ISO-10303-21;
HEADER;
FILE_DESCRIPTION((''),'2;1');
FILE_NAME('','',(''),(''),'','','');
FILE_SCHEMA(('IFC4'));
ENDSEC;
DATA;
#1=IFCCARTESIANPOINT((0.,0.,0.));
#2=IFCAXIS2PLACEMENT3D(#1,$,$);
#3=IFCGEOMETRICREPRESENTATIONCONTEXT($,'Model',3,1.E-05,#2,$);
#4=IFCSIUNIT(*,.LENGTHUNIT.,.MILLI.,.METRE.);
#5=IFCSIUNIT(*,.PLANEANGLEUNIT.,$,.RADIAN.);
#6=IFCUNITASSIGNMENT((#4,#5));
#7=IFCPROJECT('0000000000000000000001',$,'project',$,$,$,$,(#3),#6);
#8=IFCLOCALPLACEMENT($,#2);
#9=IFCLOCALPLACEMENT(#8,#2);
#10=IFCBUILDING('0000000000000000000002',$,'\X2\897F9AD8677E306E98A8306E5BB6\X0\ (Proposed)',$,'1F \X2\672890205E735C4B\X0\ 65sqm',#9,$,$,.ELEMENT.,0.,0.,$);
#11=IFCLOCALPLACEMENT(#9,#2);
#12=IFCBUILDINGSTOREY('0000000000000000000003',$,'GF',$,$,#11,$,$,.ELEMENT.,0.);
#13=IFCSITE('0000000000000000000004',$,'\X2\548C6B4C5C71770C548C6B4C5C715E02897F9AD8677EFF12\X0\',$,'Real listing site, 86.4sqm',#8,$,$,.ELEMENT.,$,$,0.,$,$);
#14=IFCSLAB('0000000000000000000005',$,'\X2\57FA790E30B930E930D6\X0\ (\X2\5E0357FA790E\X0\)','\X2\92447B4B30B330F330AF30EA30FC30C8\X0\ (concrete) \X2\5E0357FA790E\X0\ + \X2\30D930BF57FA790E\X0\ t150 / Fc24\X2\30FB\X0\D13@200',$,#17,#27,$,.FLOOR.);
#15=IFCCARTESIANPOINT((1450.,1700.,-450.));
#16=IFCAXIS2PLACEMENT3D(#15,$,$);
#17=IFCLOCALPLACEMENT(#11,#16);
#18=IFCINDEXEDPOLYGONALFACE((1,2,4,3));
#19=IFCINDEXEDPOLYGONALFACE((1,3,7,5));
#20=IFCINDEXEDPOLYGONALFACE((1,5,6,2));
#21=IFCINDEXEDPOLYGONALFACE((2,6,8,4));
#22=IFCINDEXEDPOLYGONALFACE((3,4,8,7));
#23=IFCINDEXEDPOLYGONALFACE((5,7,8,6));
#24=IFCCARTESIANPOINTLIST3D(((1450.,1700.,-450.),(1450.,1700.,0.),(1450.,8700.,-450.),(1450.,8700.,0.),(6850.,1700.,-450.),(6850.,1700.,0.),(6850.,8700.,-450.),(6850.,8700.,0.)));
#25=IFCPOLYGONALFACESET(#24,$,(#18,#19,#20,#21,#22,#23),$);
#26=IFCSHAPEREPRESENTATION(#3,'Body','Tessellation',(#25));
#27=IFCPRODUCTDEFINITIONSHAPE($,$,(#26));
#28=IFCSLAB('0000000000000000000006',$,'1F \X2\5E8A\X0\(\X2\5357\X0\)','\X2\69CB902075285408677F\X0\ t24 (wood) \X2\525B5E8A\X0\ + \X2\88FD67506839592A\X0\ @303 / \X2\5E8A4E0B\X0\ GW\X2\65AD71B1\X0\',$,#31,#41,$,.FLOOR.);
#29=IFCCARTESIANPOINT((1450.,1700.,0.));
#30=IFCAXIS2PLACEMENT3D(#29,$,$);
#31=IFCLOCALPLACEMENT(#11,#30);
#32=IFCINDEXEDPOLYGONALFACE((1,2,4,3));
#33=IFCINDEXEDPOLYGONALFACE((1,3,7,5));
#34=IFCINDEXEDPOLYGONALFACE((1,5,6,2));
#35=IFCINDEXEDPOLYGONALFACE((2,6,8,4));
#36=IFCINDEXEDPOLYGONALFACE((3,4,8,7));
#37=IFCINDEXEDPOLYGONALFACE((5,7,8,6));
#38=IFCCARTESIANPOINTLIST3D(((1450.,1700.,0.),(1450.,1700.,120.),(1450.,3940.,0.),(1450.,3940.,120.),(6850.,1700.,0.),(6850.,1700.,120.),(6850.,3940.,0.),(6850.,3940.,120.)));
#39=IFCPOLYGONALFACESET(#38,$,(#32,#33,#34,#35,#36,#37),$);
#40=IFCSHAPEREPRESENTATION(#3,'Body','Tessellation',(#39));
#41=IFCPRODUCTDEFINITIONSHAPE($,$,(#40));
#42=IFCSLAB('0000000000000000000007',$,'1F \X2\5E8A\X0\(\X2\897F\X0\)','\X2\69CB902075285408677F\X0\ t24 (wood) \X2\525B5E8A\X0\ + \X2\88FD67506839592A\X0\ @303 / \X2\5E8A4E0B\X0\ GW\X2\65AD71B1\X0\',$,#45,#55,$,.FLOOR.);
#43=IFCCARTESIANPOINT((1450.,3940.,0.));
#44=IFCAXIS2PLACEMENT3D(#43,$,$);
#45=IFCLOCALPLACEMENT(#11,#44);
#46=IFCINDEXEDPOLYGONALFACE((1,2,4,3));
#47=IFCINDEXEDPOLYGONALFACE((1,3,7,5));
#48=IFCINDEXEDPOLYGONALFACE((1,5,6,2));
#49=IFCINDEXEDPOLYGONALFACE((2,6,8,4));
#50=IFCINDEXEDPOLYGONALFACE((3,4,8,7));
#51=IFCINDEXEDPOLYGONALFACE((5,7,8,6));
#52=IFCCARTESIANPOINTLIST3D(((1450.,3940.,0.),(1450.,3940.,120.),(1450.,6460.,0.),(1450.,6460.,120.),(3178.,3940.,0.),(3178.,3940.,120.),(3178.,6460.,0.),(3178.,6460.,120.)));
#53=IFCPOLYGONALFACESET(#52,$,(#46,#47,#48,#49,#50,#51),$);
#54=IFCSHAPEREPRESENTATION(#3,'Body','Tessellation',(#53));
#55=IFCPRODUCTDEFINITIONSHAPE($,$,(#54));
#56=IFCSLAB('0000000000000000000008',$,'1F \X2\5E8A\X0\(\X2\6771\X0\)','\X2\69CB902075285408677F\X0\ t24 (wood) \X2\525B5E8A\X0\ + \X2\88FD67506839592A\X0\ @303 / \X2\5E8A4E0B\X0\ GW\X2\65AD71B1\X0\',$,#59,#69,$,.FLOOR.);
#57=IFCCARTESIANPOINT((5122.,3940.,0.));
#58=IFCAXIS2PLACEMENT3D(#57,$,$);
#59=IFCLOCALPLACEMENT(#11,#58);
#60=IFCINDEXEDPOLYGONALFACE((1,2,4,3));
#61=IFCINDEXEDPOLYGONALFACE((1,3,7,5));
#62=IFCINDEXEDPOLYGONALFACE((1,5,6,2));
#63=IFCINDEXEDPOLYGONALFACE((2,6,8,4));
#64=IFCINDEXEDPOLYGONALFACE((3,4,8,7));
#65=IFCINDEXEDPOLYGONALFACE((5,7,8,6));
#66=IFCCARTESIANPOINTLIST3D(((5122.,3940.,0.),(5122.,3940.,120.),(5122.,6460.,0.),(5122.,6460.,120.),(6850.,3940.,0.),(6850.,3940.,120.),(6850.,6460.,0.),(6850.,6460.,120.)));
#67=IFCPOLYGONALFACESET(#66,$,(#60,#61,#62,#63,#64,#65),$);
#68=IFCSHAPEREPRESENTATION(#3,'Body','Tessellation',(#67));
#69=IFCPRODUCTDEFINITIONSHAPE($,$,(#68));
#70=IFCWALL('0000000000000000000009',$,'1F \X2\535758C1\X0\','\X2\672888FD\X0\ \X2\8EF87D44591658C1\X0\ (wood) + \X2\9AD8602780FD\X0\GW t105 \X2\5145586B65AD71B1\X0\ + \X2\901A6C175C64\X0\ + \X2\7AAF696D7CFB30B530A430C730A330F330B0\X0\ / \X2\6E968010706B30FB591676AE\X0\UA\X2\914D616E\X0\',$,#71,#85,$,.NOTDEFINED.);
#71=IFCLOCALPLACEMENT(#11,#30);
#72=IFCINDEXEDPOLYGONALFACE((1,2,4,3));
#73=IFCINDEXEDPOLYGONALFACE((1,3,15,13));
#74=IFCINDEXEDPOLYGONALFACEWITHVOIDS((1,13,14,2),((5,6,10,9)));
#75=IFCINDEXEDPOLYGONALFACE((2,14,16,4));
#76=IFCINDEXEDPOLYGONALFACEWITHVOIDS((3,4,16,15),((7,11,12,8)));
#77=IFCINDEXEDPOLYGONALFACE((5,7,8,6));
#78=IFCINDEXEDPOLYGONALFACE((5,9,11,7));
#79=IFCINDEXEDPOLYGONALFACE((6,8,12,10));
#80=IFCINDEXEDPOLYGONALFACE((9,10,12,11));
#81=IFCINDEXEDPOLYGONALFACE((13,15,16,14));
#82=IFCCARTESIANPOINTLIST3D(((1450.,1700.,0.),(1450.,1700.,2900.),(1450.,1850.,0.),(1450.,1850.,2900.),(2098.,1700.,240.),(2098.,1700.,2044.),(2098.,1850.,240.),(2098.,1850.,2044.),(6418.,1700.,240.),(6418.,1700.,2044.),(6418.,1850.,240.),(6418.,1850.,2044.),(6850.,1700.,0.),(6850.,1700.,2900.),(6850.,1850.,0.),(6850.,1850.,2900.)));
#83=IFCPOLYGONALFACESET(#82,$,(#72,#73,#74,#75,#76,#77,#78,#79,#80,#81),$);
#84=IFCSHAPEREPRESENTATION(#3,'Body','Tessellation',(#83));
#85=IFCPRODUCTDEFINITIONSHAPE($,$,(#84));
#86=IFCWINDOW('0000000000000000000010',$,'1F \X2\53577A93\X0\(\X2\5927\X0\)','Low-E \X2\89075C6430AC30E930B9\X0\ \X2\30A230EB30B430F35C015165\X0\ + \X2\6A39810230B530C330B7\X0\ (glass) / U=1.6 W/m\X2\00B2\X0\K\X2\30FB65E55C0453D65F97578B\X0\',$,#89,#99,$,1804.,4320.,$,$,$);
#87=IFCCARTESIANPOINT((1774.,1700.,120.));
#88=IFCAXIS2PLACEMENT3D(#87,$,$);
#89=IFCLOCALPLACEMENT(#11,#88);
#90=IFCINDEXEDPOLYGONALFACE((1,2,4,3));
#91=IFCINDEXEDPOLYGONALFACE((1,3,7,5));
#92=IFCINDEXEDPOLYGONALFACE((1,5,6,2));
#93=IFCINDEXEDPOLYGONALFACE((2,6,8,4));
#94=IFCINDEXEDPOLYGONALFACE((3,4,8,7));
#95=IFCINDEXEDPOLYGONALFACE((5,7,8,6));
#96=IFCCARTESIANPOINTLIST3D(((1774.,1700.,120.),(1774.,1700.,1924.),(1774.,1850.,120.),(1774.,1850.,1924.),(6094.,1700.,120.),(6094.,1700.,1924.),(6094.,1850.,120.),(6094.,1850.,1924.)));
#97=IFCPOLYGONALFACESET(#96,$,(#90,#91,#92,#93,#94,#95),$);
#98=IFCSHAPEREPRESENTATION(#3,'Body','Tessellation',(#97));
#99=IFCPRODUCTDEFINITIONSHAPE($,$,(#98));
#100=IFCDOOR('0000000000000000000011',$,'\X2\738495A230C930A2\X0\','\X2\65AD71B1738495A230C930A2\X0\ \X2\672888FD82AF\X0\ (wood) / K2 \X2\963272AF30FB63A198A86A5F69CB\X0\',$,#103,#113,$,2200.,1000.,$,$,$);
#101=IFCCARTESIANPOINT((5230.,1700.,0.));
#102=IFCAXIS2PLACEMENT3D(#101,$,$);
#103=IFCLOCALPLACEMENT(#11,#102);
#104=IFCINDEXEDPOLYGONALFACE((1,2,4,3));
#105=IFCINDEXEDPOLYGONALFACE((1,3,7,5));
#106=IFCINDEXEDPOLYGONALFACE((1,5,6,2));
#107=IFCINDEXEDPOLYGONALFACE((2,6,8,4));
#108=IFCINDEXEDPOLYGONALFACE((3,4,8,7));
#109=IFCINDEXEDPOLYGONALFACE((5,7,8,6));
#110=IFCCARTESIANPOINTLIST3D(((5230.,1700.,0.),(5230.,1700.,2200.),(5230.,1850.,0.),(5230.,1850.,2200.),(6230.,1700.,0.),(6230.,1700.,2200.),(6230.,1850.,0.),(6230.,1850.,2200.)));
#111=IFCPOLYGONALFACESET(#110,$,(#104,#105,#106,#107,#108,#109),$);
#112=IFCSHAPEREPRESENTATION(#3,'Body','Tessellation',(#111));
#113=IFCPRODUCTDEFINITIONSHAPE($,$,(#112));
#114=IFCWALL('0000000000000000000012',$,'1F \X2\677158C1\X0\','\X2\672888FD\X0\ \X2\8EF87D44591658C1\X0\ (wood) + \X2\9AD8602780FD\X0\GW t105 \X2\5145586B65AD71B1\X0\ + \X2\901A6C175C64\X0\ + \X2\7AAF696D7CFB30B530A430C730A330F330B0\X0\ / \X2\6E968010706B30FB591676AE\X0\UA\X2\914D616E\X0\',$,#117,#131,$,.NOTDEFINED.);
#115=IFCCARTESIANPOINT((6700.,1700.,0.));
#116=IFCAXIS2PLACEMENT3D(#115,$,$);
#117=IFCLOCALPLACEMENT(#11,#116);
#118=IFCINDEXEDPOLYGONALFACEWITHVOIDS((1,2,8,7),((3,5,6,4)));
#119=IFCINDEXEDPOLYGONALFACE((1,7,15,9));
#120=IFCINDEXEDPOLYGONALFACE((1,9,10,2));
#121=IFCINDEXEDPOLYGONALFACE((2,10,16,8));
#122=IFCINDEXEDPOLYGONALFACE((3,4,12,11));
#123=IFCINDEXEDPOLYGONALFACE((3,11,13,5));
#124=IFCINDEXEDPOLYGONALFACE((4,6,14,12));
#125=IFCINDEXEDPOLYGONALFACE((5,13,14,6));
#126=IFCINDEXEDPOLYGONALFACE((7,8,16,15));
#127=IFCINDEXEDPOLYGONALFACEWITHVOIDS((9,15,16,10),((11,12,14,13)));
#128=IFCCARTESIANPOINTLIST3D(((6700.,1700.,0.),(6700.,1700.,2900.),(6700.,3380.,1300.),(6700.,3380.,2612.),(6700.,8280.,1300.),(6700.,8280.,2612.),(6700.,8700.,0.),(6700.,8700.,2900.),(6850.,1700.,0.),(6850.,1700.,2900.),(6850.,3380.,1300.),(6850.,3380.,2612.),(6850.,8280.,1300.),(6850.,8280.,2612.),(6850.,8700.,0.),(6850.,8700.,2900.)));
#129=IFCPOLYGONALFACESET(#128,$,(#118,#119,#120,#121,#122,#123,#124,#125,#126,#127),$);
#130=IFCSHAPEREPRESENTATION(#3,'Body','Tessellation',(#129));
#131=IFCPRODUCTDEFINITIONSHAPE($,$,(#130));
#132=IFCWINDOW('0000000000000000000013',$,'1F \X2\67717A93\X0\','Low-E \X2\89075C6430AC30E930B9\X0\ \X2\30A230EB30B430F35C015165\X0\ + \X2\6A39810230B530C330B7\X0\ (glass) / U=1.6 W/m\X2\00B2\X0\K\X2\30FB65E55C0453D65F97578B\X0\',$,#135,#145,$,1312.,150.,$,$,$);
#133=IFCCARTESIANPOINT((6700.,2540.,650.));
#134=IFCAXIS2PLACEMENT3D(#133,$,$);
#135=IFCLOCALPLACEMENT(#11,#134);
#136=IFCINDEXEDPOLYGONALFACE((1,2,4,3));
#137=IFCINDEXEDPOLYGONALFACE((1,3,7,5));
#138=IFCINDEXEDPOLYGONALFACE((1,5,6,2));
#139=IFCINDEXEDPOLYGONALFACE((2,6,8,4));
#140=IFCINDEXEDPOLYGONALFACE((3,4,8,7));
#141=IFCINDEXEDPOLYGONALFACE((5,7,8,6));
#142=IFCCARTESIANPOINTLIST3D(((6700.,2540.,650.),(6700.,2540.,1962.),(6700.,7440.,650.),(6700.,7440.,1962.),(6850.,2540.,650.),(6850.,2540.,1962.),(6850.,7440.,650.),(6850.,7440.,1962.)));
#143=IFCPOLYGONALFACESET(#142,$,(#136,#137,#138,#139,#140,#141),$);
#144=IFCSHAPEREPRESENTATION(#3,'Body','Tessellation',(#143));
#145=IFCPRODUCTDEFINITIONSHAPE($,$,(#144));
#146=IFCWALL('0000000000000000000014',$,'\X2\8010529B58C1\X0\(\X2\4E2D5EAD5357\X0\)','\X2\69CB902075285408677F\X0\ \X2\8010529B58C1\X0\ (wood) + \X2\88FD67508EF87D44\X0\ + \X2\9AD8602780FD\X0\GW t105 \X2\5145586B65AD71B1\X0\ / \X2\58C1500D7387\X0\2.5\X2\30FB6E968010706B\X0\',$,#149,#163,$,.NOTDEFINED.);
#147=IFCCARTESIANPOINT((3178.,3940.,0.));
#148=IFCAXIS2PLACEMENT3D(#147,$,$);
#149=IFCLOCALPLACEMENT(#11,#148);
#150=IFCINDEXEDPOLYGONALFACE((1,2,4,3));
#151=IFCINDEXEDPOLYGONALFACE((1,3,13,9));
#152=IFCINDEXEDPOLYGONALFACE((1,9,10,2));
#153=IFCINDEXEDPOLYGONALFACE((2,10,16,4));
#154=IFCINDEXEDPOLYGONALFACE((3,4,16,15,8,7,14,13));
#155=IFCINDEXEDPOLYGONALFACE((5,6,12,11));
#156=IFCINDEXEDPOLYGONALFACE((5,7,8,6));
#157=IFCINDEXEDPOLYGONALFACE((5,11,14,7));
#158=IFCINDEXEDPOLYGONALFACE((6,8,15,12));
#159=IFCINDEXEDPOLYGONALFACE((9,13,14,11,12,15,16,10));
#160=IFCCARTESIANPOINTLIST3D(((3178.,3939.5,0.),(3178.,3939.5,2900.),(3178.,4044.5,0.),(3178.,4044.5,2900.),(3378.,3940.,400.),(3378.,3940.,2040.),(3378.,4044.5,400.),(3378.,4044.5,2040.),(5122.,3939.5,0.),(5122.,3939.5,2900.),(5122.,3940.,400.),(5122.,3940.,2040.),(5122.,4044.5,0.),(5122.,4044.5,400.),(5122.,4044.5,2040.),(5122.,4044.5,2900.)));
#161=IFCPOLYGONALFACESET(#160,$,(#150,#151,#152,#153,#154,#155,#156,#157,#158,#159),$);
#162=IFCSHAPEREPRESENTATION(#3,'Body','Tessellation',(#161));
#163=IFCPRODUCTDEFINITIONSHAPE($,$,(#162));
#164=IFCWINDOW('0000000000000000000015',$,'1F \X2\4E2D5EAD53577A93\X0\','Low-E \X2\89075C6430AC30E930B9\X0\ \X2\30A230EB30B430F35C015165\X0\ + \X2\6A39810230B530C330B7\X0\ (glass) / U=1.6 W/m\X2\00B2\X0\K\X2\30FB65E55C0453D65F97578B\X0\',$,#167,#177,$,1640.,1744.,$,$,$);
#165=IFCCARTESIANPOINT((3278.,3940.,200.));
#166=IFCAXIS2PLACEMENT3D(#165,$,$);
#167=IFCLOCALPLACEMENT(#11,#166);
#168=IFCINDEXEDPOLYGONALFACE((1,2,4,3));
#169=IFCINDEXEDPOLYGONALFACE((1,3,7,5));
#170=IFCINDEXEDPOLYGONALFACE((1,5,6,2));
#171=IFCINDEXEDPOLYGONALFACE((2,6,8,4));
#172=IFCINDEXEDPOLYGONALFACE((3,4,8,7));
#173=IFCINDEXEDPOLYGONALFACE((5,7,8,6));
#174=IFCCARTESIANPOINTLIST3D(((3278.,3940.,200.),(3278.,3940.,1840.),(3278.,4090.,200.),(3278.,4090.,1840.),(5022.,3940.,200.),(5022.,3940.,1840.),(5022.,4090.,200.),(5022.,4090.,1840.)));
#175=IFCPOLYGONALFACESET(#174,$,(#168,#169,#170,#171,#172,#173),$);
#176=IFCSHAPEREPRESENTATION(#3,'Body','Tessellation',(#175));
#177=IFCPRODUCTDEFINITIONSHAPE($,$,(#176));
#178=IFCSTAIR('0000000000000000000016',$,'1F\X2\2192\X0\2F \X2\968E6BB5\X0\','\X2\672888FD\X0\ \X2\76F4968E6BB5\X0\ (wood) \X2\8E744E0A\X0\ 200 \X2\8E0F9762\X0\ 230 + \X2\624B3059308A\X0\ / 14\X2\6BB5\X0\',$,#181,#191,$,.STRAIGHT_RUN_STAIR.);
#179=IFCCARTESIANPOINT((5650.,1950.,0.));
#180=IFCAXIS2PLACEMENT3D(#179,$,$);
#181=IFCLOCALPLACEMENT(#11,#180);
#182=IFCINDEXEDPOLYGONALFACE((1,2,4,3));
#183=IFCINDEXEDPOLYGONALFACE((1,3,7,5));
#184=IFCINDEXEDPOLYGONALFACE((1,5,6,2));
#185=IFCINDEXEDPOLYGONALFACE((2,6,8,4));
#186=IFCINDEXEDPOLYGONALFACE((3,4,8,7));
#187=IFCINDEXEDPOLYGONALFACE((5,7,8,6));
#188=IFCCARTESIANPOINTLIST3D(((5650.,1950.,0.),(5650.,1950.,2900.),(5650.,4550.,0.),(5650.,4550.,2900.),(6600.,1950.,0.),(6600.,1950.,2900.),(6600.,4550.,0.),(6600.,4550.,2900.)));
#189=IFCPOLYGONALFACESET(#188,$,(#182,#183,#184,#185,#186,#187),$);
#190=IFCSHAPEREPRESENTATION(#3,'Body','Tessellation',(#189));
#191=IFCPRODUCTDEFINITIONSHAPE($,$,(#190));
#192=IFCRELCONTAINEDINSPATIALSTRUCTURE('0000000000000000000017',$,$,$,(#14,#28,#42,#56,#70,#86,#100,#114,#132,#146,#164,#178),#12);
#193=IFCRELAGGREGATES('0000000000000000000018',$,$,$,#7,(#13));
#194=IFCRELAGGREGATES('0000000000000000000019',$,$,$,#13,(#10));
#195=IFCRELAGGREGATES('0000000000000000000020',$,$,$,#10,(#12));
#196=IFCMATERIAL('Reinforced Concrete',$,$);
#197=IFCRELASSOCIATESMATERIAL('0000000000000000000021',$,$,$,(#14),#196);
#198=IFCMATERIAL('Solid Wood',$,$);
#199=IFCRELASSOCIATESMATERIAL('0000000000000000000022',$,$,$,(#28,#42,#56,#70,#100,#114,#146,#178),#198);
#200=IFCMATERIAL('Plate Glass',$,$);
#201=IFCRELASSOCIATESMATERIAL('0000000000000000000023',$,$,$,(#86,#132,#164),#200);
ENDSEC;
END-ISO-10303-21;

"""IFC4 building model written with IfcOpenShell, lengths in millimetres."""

from ifc_helpers import new_model, si_unit, frame, frame_2d, origin, place, context, project, spatial, rectangle, extrude, material, element, fill, save


model = new_model("IFC4")

# Units and contexts
model_context = context("Model", 3, precision=1e-05, world=origin())
ifc_project = project(units=[si_unit("LENGTHUNIT", "METRE", prefix="MILLI"), si_unit("PLANEANGLEUNIT", "RADIAN")], contexts=[model_context])

# Site, building, storey
site_placement = place(None, origin())
site = spatial("IfcSite", under=ifc_project, at=site_placement, Name="和歌山県和歌山市西高松２", ObjectType="Real listing site, 86.4sqm", CompositionType="ELEMENT", RefElevation=0.0)
building_placement = place(site_placement, origin())
building = spatial("IfcBuilding", under=site, at=building_placement, Name="西高松の風の家 (Proposed)", ObjectType="1F 木造平屋 65sqm", CompositionType="ELEMENT", ElevationOfRefHeight=0.0, ElevationOfTerrain=0.0)
storey_placement = place(building_placement, origin())
storey = spatial("IfcBuildingStorey", under=building, at=storey_placement, Name="GF", CompositionType="ELEMENT", Elevation=0.0)

# Slabs
ifc_material_1 = material(Name="Reinforced Concrete")
slab_1_placement = place(storey_placement, frame((1450.0, 1700.0, -450.0)))
element("IfcSlab", 1, at=slab_1_placement, inside=storey, material=ifc_material_1, Name="基礎スラブ (布基礎)", Description="鉄筋コンクリート (concrete) 布基礎 + ベタ基礎 t150 / Fc24・D13@200", PredefinedType="FLOOR", context=model_context, shape_type="SweptSolid", body=[
    extrude(rectangle(XDim=5400.0, YDim=7000.0, at=frame_2d((2700.0, 3500.0))), frame((1450.0, 1700.0, -450.0)), (0.0, 0.0, 1.0), 450.0),
])
ifc_material_2 = material(Name="Solid Wood")
slab_2_placement = place(storey_placement, frame((1450.0, 1700.0, 0.0)))
element("IfcSlab", 2, at=slab_2_placement, inside=storey, material=ifc_material_2, Name="1F 床(南)", Description="構造用合板 t24 (wood) 剛床 + 製材根太 @303 / 床下 GW断熱", PredefinedType="FLOOR", context=model_context, shape_type="SweptSolid", body=[
    extrude(rectangle(XDim=5400.0, YDim=2240.0, at=frame_2d((2700.0, 1120.0))), frame((1450.0, 1700.0, 0.0)), (0.0, 0.0, 1.0), 120.0),
])
slab_3_placement = place(storey_placement, frame((1450.0, 3940.0, 0.0)))
element("IfcSlab", 3, at=slab_3_placement, inside=storey, material=ifc_material_2, Name="1F 床(西)", Description="構造用合板 t24 (wood) 剛床 + 製材根太 @303 / 床下 GW断熱", PredefinedType="FLOOR", context=model_context, shape_type="SweptSolid", body=[
    extrude(rectangle(XDim=1728.0, YDim=2520.0, at=frame_2d((864.0, 1260.0))), frame((1450.0, 3940.0, 0.0)), (0.0, 0.0, 1.0), 120.0),
])
slab_4_placement = place(storey_placement, frame((5122.0, 3940.0, 0.0)))
element("IfcSlab", 4, at=slab_4_placement, inside=storey, material=ifc_material_2, Name="1F 床(東)", Description="構造用合板 t24 (wood) 剛床 + 製材根太 @303 / 床下 GW断熱", PredefinedType="FLOOR", context=model_context, shape_type="SweptSolid", body=[
    extrude(rectangle(XDim=1728.0, YDim=2520.0, at=frame_2d((864.0, 1260.0))), frame((5122.0, 3940.0, 0.0)), (0.0, 0.0, 1.0), 120.0),
])

# Wall, openings, window, door
wall_1_placement = place(storey_placement, frame((1450.0, 1700.0, 0.0)))
wall_1 = element("IfcWall", 5, at=wall_1_placement, inside=storey, material=ifc_material_2, Name="1F 南壁", Description="木製 軸組外壁 (wood) + 高性能GW t105 充填断熱 + 通気層 + 窯業系サイディング / 準耐火・外皮UA配慮", PredefinedType="NOTDEFINED", context=model_context, shape_type="SweptSolid", body=[
    extrude(rectangle(XDim=5400.0, YDim=150.0, at=frame_2d((2700.0, 75.0))), frame((1450.0, 1700.0, 0.0)), (0.0, 0.0, 1.0), 2900.0),
])
opening_1_placement = place(storey_placement, frame((1774.0, 1700.0, 120.0)))
opening_1 = element("IfcOpeningElement", 6, at=opening_1_placement, cuts=wall_1, PredefinedType="NOTDEFINED", context=model_context, shape_type="SweptSolid", body=[
    extrude(rectangle(XDim=4320.0, YDim=150.0, at=frame_2d((2160.0, 75.0))), frame((1774.0, 1700.0, 120.0)), (0.0, 0.0, 1.0), 1804.0),
])
opening_2_placement = place(storey_placement, frame((5230.0, 1700.0, 0.0)))
opening_2 = element("IfcOpeningElement", 7, at=opening_2_placement, cuts=wall_1, PredefinedType="NOTDEFINED", context=model_context, shape_type="SweptSolid", body=[
    extrude(rectangle(XDim=1000.0, YDim=150.0, at=frame_2d((500.0, 75.0))), frame((5230.0, 1700.0, 0.0)), (0.0, 0.0, 1.0), 2200.0),
])
ifc_material_3 = material(Name="Plate Glass")
window_1_placement = place(storey_placement, frame((1774.0, 1700.0, 120.0)))
window_1 = element("IfcWindow", 8, at=window_1_placement, inside=storey, material=ifc_material_3, Name="1F 南窓(大)", Description="Low-E 複層ガラス アルゴン封入 + 樹脂サッシ (glass) / U=1.6 W/m²K・日射取得型", OverallHeight=1804.0, OverallWidth=4320.0, context=model_context, shape_type="SweptSolid", body=[
    extrude(rectangle(XDim=4320.0, YDim=150.0, at=frame_2d((2160.0, 75.0))), frame((1774.0, 1700.0, 120.0)), (0.0, 0.0, 1.0), 1804.0),
])
fill(opening_1, window_1)
door_placement = place(storey_placement, frame((5230.0, 1700.0, 0.0)))
door = element("IfcDoor", 9, at=door_placement, inside=storey, material=ifc_material_2, Name="玄関ドア", Description="断熱玄関ドア 木製芯 (wood) / K2 防犯・採風機構", OverallHeight=2200.0, OverallWidth=1000.0, context=model_context, shape_type="SweptSolid", body=[
    extrude(rectangle(XDim=1000.0, YDim=150.0, at=frame_2d((500.0, 75.0))), frame((5230.0, 1700.0, 0.0)), (0.0, 0.0, 1.0), 2200.0),
])
fill(opening_2, door)

# Walls, openings, windows
wall_2_placement = place(storey_placement, frame((6700.0, 1700.0, 0.0)))
wall_2 = element("IfcWall", 10, at=wall_2_placement, inside=storey, material=ifc_material_2, Name="1F 東壁", Description="木製 軸組外壁 (wood) + 高性能GW t105 充填断熱 + 通気層 + 窯業系サイディング / 準耐火・外皮UA配慮", PredefinedType="NOTDEFINED", context=model_context, shape_type="SweptSolid", body=[
    extrude(rectangle(XDim=150.0, YDim=7000.0, at=frame_2d((75.0, 3500.0))), frame((6700.0, 1700.0, 0.0)), (0.0, 0.0, 1.0), 2900.0),
])
opening_3_placement = place(storey_placement, frame((6700.0, 2540.0, 650.0)))
opening_3 = element("IfcOpeningElement", 11, at=opening_3_placement, cuts=wall_2, PredefinedType="NOTDEFINED", context=model_context, shape_type="SweptSolid", body=[
    extrude(rectangle(XDim=150.0, YDim=4900.0, at=frame_2d((75.0, 2450.0))), frame((6700.0, 2540.0, 650.0)), (0.0, 0.0, 1.0), 1312.0),
])
window_2_placement = place(storey_placement, frame((6700.0, 2540.0, 650.0)))
window_2 = element("IfcWindow", 12, at=window_2_placement, inside=storey, material=ifc_material_3, Name="1F 東窓", Description="Low-E 複層ガラス アルゴン封入 + 樹脂サッシ (glass) / U=1.6 W/m²K・日射取得型", OverallHeight=1312.0, OverallWidth=150.0, context=model_context, shape_type="SweptSolid", body=[
    extrude(rectangle(XDim=150.0, YDim=4900.0, at=frame_2d((75.0, 2450.0))), frame((6700.0, 2540.0, 650.0)), (0.0, 0.0, 1.0), 1312.0),
])
fill(opening_3, window_2)
wall_3_placement = place(storey_placement, frame((3178.0, 3940.0, 0.0)))
wall_3 = element("IfcWall", 13, at=wall_3_placement, inside=storey, material=ifc_material_2, Name="耐力壁(中庭南)", Description="構造用合板 耐力壁 (wood) + 製材軸組 + 高性能GW t105 充填断熱 / 壁倍率2.5・準耐火", PredefinedType="NOTDEFINED", context=model_context, shape_type="SweptSolid", body=[
    extrude(rectangle(XDim=1944.0, YDim=105.0, at=frame_2d((972.0, 52.0))), frame((3178.0, 3940.0, 0.0)), (0.0, 0.0, 1.0), 2900.0),
])
opening_4_placement = place(storey_placement, frame((3278.0, 3940.0, 200.0)))
opening_4 = element("IfcOpeningElement", 14, at=opening_4_placement, cuts=wall_3, PredefinedType="NOTDEFINED", context=model_context, shape_type="SweptSolid", body=[
    extrude(rectangle(XDim=1744.0, YDim=150.0, at=frame_2d((872.0, 75.0))), frame((3278.0, 3940.0, 200.0)), (0.0, 0.0, 1.0), 1640.0),
])
window_3_placement = place(storey_placement, frame((3278.0, 3940.0, 200.0)))
window_3 = element("IfcWindow", 15, at=window_3_placement, inside=storey, material=ifc_material_3, Name="1F 中庭南窓", Description="Low-E 複層ガラス アルゴン封入 + 樹脂サッシ (glass) / U=1.6 W/m²K・日射取得型", OverallHeight=1640.0, OverallWidth=1744.0, context=model_context, shape_type="SweptSolid", body=[
    extrude(rectangle(XDim=1744.0, YDim=150.0, at=frame_2d((872.0, 75.0))), frame((3278.0, 3940.0, 200.0)), (0.0, 0.0, 1.0), 1640.0),
])
fill(opening_4, window_3)

# Stair
stair_placement = place(storey_placement, frame((5650.0, 1950.0, 0.0)))
element("IfcStair", 16, at=stair_placement, inside=storey, material=ifc_material_2, Name="1F→2F 階段", Description="木製 直階段 (wood) 蹴上 200 踏面 230 + 手すり / 14段", PredefinedType="STRAIGHT_RUN_STAIR", context=model_context, shape_type="SweptSolid", body=[
    extrude(rectangle(XDim=950.0, YDim=2600.0, at=frame_2d((475.0, 1300.0))), frame((5650.0, 1950.0, 0.0)), (0.0, 0.0, 1.0), 2900.0),
])

save(model, "model.ifc")
